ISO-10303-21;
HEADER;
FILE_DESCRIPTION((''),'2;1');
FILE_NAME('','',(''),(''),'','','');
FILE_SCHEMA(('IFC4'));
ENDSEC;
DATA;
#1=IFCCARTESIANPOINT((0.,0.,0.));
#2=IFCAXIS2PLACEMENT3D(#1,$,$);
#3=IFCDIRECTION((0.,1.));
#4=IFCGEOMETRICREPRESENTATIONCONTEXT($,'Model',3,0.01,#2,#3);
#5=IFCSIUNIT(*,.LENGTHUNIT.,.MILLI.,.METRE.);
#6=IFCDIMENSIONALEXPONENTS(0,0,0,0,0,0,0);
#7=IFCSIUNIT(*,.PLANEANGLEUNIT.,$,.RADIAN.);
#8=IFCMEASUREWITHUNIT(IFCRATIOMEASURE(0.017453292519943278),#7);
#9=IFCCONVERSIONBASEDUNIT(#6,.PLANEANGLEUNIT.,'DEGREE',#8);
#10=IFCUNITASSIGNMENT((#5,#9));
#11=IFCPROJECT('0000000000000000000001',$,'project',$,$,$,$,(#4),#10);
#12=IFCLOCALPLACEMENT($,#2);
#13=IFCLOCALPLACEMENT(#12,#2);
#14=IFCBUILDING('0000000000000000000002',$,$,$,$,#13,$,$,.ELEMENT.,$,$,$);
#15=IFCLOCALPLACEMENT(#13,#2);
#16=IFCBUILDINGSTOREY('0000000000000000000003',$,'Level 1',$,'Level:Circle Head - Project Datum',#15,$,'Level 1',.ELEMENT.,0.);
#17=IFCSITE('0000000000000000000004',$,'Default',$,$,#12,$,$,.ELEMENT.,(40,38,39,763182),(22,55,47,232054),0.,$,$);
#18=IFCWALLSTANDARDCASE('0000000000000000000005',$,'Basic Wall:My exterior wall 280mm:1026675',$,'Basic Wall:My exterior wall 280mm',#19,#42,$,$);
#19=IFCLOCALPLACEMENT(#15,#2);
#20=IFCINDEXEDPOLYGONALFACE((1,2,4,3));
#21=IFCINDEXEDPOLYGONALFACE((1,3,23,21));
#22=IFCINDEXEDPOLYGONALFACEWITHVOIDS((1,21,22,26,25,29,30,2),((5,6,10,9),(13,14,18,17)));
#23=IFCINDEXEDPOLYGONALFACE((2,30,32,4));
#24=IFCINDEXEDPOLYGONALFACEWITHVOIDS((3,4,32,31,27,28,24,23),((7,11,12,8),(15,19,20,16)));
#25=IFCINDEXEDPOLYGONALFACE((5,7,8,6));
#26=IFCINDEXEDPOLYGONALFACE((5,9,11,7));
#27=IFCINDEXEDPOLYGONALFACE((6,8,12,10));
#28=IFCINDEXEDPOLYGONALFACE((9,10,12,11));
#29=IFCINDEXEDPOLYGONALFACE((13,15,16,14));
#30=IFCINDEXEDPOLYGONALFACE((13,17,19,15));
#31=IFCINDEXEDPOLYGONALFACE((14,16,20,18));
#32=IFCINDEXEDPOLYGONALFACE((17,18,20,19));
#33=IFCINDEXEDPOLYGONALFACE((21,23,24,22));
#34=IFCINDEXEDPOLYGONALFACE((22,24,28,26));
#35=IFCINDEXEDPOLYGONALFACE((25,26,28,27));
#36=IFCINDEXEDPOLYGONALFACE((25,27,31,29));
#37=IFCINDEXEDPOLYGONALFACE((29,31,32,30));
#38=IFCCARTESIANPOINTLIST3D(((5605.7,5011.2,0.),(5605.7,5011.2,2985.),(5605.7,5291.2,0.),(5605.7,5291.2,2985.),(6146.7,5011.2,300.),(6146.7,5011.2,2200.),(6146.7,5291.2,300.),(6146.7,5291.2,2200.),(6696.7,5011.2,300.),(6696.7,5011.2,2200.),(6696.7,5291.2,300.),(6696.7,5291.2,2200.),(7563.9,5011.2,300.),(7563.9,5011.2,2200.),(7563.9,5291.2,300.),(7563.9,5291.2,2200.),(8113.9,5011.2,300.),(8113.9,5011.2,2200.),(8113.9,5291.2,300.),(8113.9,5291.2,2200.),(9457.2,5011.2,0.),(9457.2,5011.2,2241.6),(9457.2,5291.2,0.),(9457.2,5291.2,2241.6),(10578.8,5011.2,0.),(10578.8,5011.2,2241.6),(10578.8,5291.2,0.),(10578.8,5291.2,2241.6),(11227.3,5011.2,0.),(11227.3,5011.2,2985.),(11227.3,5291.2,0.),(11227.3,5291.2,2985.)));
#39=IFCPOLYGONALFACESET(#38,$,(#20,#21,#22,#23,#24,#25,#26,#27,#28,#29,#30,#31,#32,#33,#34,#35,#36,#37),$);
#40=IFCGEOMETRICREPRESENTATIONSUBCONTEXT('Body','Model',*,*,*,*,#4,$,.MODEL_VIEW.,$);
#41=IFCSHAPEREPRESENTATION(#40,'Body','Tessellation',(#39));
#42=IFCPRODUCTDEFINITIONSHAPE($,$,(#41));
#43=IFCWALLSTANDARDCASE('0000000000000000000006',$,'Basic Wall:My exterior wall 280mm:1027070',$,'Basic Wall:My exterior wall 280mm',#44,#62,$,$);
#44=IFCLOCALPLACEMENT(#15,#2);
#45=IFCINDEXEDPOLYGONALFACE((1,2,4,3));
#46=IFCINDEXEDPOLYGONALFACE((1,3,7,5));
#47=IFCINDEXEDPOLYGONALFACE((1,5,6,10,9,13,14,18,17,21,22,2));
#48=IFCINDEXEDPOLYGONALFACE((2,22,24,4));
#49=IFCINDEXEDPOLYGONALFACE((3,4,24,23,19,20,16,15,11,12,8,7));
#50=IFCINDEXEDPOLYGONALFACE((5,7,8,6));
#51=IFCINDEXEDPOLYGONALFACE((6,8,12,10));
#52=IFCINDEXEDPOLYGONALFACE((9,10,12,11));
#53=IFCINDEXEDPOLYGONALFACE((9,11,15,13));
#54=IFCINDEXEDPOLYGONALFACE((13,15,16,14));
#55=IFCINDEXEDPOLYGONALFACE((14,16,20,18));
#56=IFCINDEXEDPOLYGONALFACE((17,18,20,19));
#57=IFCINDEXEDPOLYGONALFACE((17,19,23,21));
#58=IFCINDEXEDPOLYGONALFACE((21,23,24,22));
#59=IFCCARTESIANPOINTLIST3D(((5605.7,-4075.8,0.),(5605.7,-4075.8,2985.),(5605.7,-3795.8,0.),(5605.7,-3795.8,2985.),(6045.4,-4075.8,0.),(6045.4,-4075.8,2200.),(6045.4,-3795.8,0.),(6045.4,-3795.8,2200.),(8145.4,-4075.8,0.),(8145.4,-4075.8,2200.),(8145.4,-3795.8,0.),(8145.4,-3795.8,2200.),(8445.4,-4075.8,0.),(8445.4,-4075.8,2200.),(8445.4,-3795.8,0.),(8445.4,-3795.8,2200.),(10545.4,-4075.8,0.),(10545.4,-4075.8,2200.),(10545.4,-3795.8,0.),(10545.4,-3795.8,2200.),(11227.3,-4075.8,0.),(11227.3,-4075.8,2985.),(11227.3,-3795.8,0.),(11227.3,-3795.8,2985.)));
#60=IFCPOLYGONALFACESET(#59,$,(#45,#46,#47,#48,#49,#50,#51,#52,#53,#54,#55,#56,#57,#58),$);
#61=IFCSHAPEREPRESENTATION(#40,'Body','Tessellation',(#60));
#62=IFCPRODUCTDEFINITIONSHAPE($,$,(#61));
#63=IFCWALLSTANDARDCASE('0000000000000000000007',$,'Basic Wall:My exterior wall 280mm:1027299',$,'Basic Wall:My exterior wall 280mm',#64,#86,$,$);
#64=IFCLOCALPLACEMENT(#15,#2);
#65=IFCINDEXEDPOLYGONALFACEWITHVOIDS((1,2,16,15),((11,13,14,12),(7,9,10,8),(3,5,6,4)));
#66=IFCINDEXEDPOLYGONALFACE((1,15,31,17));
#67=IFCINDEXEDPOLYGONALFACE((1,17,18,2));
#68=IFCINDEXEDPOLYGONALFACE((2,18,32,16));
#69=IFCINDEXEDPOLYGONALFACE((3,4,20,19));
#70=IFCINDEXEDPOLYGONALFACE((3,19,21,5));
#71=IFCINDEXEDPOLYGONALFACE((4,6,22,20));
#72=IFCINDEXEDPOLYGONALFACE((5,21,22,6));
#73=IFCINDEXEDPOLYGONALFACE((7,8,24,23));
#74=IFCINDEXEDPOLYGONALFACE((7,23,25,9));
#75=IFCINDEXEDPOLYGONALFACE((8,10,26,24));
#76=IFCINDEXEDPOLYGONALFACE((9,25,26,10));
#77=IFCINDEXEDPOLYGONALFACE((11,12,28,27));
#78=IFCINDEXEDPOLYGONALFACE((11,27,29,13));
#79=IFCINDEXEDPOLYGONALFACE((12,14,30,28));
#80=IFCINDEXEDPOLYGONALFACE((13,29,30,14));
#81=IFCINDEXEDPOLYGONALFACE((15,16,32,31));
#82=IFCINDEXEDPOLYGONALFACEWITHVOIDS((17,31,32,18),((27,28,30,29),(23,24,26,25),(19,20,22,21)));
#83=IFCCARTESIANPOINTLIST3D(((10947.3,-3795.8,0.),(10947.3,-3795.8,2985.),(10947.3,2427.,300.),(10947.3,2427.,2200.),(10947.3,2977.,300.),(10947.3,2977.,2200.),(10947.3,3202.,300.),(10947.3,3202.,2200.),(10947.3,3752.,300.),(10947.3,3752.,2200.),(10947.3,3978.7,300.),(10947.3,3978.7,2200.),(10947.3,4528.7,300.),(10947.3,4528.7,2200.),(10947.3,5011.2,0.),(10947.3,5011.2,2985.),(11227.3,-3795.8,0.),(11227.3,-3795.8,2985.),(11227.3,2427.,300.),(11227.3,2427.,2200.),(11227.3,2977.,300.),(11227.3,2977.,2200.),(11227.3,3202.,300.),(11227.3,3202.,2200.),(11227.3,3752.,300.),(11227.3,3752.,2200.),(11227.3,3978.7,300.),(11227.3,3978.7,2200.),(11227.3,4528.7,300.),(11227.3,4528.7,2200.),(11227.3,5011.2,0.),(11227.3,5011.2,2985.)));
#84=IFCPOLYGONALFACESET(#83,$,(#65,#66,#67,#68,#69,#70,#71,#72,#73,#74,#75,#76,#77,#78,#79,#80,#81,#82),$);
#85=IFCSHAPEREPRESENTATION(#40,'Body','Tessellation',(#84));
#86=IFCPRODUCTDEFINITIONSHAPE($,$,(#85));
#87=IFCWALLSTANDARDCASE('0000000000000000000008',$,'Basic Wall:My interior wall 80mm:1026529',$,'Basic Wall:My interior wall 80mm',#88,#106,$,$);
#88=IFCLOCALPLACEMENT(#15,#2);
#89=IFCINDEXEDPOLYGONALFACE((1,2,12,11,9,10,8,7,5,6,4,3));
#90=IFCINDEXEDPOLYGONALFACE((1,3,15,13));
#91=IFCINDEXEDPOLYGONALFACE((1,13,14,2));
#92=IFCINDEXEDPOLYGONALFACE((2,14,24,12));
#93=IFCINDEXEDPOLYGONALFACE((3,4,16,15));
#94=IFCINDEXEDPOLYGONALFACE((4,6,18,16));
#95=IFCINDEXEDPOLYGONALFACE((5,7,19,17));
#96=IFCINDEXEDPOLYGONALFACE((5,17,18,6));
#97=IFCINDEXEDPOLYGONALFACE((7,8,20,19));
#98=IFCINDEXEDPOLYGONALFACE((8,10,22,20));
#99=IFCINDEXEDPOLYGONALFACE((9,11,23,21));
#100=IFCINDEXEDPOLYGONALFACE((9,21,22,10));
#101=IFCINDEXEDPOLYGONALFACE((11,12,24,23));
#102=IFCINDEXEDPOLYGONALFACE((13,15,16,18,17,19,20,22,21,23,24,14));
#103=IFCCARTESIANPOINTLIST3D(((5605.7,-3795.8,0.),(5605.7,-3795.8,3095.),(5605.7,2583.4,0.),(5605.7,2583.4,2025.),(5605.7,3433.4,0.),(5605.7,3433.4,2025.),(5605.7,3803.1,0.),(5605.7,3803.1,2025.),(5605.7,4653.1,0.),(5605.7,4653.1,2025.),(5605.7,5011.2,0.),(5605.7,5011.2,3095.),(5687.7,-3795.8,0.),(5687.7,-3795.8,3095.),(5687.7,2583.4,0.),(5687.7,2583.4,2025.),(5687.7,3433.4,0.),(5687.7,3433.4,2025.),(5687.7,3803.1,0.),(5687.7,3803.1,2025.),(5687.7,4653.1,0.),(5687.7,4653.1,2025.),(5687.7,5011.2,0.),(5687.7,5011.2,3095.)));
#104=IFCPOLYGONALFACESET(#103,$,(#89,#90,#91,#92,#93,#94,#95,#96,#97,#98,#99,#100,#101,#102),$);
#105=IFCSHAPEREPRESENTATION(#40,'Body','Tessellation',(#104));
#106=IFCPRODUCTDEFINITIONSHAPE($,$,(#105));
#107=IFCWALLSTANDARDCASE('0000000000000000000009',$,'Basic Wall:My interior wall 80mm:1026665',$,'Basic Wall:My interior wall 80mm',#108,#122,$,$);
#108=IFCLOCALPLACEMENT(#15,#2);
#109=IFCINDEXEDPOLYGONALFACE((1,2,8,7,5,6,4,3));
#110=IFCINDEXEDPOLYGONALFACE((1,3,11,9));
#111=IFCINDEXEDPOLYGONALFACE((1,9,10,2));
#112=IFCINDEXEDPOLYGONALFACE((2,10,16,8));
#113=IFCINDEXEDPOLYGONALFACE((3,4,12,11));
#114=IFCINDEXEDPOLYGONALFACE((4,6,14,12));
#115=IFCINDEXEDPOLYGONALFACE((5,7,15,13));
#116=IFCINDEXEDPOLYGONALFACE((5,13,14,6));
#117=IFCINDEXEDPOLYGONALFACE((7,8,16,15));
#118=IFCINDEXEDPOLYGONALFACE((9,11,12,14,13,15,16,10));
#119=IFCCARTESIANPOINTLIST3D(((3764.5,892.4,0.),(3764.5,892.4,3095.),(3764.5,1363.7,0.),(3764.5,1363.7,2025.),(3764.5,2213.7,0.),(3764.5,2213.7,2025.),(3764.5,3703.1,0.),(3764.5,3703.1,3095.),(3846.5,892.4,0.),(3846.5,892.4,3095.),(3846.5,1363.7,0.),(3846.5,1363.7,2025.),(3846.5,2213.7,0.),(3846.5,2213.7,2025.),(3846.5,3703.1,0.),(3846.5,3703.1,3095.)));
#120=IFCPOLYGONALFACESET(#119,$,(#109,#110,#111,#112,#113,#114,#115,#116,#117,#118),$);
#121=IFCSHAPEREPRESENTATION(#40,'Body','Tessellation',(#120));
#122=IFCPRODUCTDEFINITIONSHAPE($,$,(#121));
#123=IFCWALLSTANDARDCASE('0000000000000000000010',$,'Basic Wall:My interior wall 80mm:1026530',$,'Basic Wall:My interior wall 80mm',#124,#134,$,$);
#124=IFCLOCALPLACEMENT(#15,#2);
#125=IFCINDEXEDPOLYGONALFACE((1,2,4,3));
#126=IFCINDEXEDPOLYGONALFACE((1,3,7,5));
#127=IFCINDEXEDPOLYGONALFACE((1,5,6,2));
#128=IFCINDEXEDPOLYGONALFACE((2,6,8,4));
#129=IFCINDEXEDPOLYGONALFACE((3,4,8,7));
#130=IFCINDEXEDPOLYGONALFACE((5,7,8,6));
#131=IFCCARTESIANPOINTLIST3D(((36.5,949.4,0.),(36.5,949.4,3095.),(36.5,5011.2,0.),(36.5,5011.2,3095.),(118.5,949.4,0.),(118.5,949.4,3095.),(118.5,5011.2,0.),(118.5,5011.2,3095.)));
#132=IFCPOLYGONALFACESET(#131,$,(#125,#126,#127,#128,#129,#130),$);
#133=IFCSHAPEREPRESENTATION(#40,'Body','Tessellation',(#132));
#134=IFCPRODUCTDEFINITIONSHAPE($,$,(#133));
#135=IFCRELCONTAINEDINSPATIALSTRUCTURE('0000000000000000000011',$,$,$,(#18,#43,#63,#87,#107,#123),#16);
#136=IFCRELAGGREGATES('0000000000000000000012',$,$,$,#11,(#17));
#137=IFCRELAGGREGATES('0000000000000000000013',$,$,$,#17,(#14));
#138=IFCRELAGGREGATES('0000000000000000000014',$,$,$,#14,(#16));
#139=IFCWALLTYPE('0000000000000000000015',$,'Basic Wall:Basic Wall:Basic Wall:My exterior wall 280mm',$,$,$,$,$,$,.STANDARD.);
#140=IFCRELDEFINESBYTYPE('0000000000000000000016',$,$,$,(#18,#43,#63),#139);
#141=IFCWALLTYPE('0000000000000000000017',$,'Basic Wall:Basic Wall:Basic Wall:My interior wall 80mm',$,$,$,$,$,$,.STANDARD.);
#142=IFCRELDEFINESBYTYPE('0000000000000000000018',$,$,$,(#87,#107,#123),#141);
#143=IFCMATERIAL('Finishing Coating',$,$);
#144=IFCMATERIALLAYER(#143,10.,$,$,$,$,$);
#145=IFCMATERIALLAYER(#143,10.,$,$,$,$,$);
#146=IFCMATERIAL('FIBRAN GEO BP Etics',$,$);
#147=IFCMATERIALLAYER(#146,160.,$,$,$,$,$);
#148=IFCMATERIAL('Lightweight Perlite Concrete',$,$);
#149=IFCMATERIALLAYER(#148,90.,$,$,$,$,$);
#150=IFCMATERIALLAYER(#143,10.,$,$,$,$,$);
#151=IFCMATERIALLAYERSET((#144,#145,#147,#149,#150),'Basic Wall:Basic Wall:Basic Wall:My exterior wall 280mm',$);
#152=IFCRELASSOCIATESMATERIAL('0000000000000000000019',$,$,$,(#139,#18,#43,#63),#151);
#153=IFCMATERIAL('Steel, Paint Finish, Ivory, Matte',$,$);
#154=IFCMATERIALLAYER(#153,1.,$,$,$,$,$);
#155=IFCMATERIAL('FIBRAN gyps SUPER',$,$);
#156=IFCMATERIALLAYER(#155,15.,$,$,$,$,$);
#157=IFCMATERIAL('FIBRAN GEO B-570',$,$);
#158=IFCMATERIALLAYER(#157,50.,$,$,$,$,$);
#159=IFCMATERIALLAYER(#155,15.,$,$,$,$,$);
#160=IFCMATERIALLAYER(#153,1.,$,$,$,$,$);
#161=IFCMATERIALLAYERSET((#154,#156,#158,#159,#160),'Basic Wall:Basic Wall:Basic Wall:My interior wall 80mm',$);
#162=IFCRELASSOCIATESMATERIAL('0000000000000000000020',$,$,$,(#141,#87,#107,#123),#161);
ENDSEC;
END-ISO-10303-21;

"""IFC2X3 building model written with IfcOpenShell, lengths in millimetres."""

from ifc_helpers import new_model, entity, si_unit, converted_unit, direction, frame, frame_2d, origin, origin_2d_with_axis, place, context, subcontext, project, spatial, rectangle, extrude, material, layer, layer_set, layer_usage, type_object, element, save


model = new_model("IFC2X3")

# Units and contexts
model_context = context("Model", 3, precision=0.01, world=origin(), true_north=direction((0.0, 1.0)))
body_context = subcontext(model_context, "Body", "Model", "MODEL_VIEW")
ifc_project = project(units=[si_unit("LENGTHUNIT", "METRE", prefix="MILLI"), converted_unit("PLANEANGLEUNIT", "DEGREE", entity("IfcRatioMeasure", 0.017453292519943278), si_unit("PLANEANGLEUNIT", "RADIAN"), dimensions=[0, 0, 0, 0, 0, 0, 0])], contexts=[model_context])

# Site, building, storey
site_placement = place(None, origin())
site = spatial("IfcSite", under=ifc_project, at=site_placement, Name="Default", CompositionType="ELEMENT", RefLatitude=(40, 38, 39, 763182), RefLongitude=(22, 55, 47, 232054), RefElevation=0.0)
building_placement = place(site_placement, origin())
building = spatial("IfcBuilding", under=site, at=building_placement, CompositionType="ELEMENT")
storey_placement = place(building_placement, origin())
storey = spatial("IfcBuildingStorey", under=building, at=storey_placement, Name="Level 1", ObjectType="Level:Circle Head - Project Datum", LongName="Level 1", CompositionType="ELEMENT", Elevation=0.0)

# Shared definitions
ifc_material_1 = material(Name="FIBRAN gyps SUPER")

# Walls, openings
ifc_material_2 = material(Name="Finishing Coating")
ifc_layer_1 = layer(ifc_material_2, 10.0)
ifc_layer_2 = layer(ifc_material_2, 10.0)
ifc_material_3 = material(Name="FIBRAN GEO BP Etics")
ifc_layer_3 = layer(ifc_material_3, 160.0)
ifc_material_4 = material(Name="Lightweight Perlite Concrete")
ifc_layer_4 = layer(ifc_material_4, 90.0)
ifc_layer_5 = layer(ifc_material_2, 10.0)
ifc_layer_set_1 = layer_set([ifc_layer_1, ifc_layer_2, ifc_layer_3, ifc_layer_4, ifc_layer_5], Name="Basic Wall:Basic Wall:Basic Wall:My exterior wall 280mm")
ifc_layer_usage_1 = layer_usage(ifc_layer_set_1, "AXIS2", "NEGATIVE", 140.0)
wall_type_1 = type_object("IfcWallType", Name="Basic Wall:Basic Wall:Basic Wall:My exterior wall 280mm", PredefinedType="STANDARD", material=ifc_layer_set_1)
wall_1_placement = place(storey_placement, frame((5605.7, 5151.2, 0.0)))
wall_1 = element("IfcWallStandardCase", 1, at=wall_1_placement, inside=storey, type_object=wall_type_1, material=ifc_layer_usage_1, Name="Basic Wall:My exterior wall 280mm:1026675", ObjectType="Basic Wall:My exterior wall 280mm", context=body_context, shape_type="SweptSolid", body=[
    extrude(rectangle(XDim=5621.6, YDim=280.0, at=frame_2d((2810.8, 0.0), x_axis=(1.0, 0.0))), origin(), (0.0, 0.0, 1.0), 2985.0),
])
opening_1_placement = place(wall_1_placement, origin())
element("IfcOpeningElement", 2, at=opening_1_placement, cuts=wall_1, ObjectType="Opening", context=body_context, shape_type="SweptSolid", body=[
    extrude(rectangle(XDim=2241.6, YDim=1121.6, at=frame_2d((0.0, 0.0), x_axis=(1.0, 0.0))), frame((4412.3, -140.0, 1120.8), z_axis=(0.0, 1.0, 0.0), x_axis=(0.0, 0.0, -1.0)), (0.0, 0.0, 1.0), 280.0),
])
opening_2_placement = place(wall_1_placement, origin())
element("IfcOpeningElement", 3, at=opening_2_placement, cuts=wall_1, ObjectType="Opening", context=body_context, shape_type="SweptSolid", body=[
    extrude(rectangle(XDim=1900.0, YDim=550.0, at=frame_2d((0.0, 0.0), x_axis=(1.0, 0.0))), frame((816.0, -140.0, 1250.0), z_axis=(0.0, 1.0, 0.0), x_axis=(0.0, 0.0, -1.0)), (0.0, 0.0, 1.0), 280.0),
])
opening_3_placement = place(wall_1_placement, origin())
element("IfcOpeningElement", 4, at=opening_3_placement, cuts=wall_1, ObjectType="Opening", context=body_context, shape_type="SweptSolid", body=[
    extrude(rectangle(XDim=1900.0, YDim=550.0, at=frame_2d((0.0, 0.0), x_axis=(1.0, 0.0))), frame((2233.1, -140.0, 1250.0), z_axis=(0.0, 1.0, 0.0), x_axis=(0.0, 0.0, -1.0)), (0.0, 0.0, 1.0), 280.0),
])
ifc_layer_usage_2 = layer_usage(ifc_layer_set_1, "AXIS2", "NEGATIVE", 140.0)
wall_2_placement = place(storey_placement, frame((11227.3, -3935.8, 0.0), z_axis=(0.0, 0.0, 1.0), x_axis=(-1.0, 0.0, 0.0)))
wall_2 = element("IfcWallStandardCase", 5, at=wall_2_placement, inside=storey, type_object=wall_type_1, material=ifc_layer_usage_2, Name="Basic Wall:My exterior wall 280mm:1027070", ObjectType="Basic Wall:My exterior wall 280mm", context=body_context, shape_type="SweptSolid", body=[
    extrude(rectangle(XDim=5621.6, YDim=280.0, at=frame_2d((2810.8, 0.0), x_axis=(1.0, 0.0))), origin(), (0.0, 0.0, 1.0), 2985.0),
])
opening_4_placement = place(wall_2_placement, origin())
element("IfcOpeningElement", 6, at=opening_4_placement, cuts=wall_2, ObjectType="Opening", context=body_context, shape_type="SweptSolid", body=[
    extrude(rectangle(XDim=2200.0, YDim=2100.0, at=frame_2d((0.0, 0.0), x_axis=(1.0, 0.0))), frame((4131.9, -140.0, 1100.0), z_axis=(0.0, 1.0, 0.0), x_axis=(0.0, 0.0, -1.0)), (0.0, 0.0, 1.0), 280.0),
])
opening_5_placement = place(wall_2_placement, origin())
element("IfcOpeningElement", 7, at=opening_5_placement, cuts=wall_2, ObjectType="Opening", context=body_context, shape_type="SweptSolid", body=[
    extrude(rectangle(XDim=2200.0, YDim=2100.0, at=frame_2d((0.0, 0.0), x_axis=(1.0, 0.0))), frame((1731.9, -140.0, 1100.0), z_axis=(0.0, 1.0, 0.0), x_axis=(0.0, 0.0, -1.0)), (0.0, 0.0, 1.0), 280.0),
])
ifc_layer_usage_3 = layer_usage(ifc_layer_set_1, "AXIS2", "NEGATIVE", 140.0)
wall_3_placement = place(storey_placement, frame((11087.3, -3795.8, 0.0), z_axis=(0.0, 0.0, 1.0), x_axis=(0.0, 1.0, 0.0)))
wall_3 = element("IfcWallStandardCase", 8, at=wall_3_placement, inside=storey, type_object=wall_type_1, material=ifc_layer_usage_3, Name="Basic Wall:My exterior wall 280mm:1027299", ObjectType="Basic Wall:My exterior wall 280mm", context=body_context, shape_type="SweptSolid", body=[
    extrude(rectangle(XDim=8807.0, YDim=280.0, at=frame_2d((4403.5, 0.0), x_axis=(-1.0, 0.0))), origin(), (0.0, 0.0, 1.0), 2985.0),
])
opening_6_placement = place(wall_3_placement, origin())
element("IfcOpeningElement", 9, at=opening_6_placement, cuts=wall_3, ObjectType="Opening", context=body_context, shape_type="SweptSolid", body=[
    extrude(rectangle(XDim=1900.0, YDim=550.0, at=frame_2d((0.0, 0.0), x_axis=(1.0, 0.0))), frame((6497.9, -140.0, 1250.0), z_axis=(0.0, 1.0, 0.0), x_axis=(0.0, 0.0, -1.0)), (0.0, 0.0, 1.0), 280.0),
])
opening_7_placement = place(wall_3_placement, origin())
element("IfcOpeningElement", 10, at=opening_7_placement, cuts=wall_3, ObjectType="Opening", context=body_context, shape_type="SweptSolid", body=[
    extrude(rectangle(XDim=1900.0, YDim=550.0, at=frame_2d((0.0, 0.0), x_axis=(1.0, 0.0))), frame((7272.9, -140.0, 1250.0), z_axis=(0.0, 1.0, 0.0), x_axis=(0.0, 0.0, -1.0)), (0.0, 0.0, 1.0), 280.0),
])
opening_8_placement = place(wall_3_placement, origin())
element("IfcOpeningElement", 11, at=opening_8_placement, cuts=wall_3, ObjectType="Opening", context=body_context, shape_type="SweptSolid", body=[
    extrude(rectangle(XDim=1900.0, YDim=550.0, at=frame_2d((0.0, 0.0), x_axis=(1.0, 0.0))), frame((8049.6, -140.0, 1250.0), z_axis=(0.0, 1.0, 0.0), x_axis=(0.0, 0.0, -1.0)), (0.0, 0.0, 1.0), 280.0),
])
ifc_material_5 = material(Name="Steel, Paint Finish, Ivory, Matte")
ifc_layer_6 = layer(ifc_material_5, 1.0)
ifc_layer_7 = layer(ifc_material_1, 15.0)
ifc_material_6 = material(Name="FIBRAN GEO B-570")
ifc_layer_8 = layer(ifc_material_6, 50.0)
ifc_layer_9 = layer(ifc_material_1, 15.0)
ifc_layer_10 = layer(ifc_material_5, 1.0)
ifc_layer_set_2 = layer_set([ifc_layer_6, ifc_layer_7, ifc_layer_8, ifc_layer_9, ifc_layer_10], Name="Basic Wall:Basic Wall:Basic Wall:My interior wall 80mm")
ifc_layer_usage_4 = layer_usage(ifc_layer_set_2, "AXIS2", "NEGATIVE", 41.0)
wall_type_2 = type_object("IfcWallType", Name="Basic Wall:Basic Wall:Basic Wall:My interior wall 80mm", PredefinedType="STANDARD", material=ifc_layer_set_2)
wall_4_placement = place(storey_placement, frame((5646.7, -3795.8, 0.0), z_axis=(0.0, 0.0, 1.0), x_axis=(0.0, 1.0, 0.0)))
wall_4 = element("IfcWallStandardCase", 12, at=wall_4_placement, inside=storey, type_object=wall_type_2, material=ifc_layer_usage_4, Name="Basic Wall:My interior wall 80mm:1026529", ObjectType="Basic Wall:My interior wall 80mm", context=body_context, shape_type="SweptSolid", body=[
    extrude(rectangle(XDim=8807.0, YDim=82.0, at=frame_2d((4403.5, 0.0), x_axis=(1.0, 0.0))), origin(), (0.0, 0.0, 1.0), 3095.0),
])
opening_9_placement = place(wall_4_placement, origin())
element("IfcOpeningElement", 13, at=opening_9_placement, cuts=wall_4, ObjectType="Opening", context=body_context, shape_type="SweptSolid", body=[
    extrude(rectangle(XDim=2025.0, YDim=850.0, at=origin_2d_with_axis()), frame((8024.0, -41.0, 1012.5), z_axis=(0.0, 1.0, 0.0), x_axis=(0.0, 0.0, -1.0)), (0.0, 0.0, 1.0), 82.0),
])
opening_10_placement = place(wall_4_placement, origin())
element("IfcOpeningElement", 14, at=opening_10_placement, cuts=wall_4, ObjectType="Opening", context=body_context, shape_type="SweptSolid", body=[
    extrude(rectangle(XDim=2025.0, YDim=850.0, at=origin_2d_with_axis()), frame((6804.2, -41.0, 1012.5), z_axis=(0.0, 1.0, 0.0), x_axis=(0.0, 0.0, -1.0)), (0.0, 0.0, 1.0), 82.0),
])

# Wall, opening
ifc_layer_usage_5 = layer_usage(ifc_layer_set_2, "AXIS2", "NEGATIVE", 41.0)
wall_5_placement = place(storey_placement, frame((3805.5, 3703.1, 0.0), z_axis=(0.0, 0.0, 1.0), x_axis=(0.0, -1.0, 0.0)))
wall_5 = element("IfcWallStandardCase", 15, at=wall_5_placement, inside=storey, type_object=wall_type_2, material=ifc_layer_usage_5, Name="Basic Wall:My interior wall 80mm:1026665", ObjectType="Basic Wall:My interior wall 80mm", context=body_context, shape_type="SweptSolid", body=[
    extrude(rectangle(XDim=2810.7, YDim=82.0, at=frame_2d((1405.4, 0.0), x_axis=(1.0, 0.0))), origin(), (0.0, 0.0, 1.0), 3095.0),
])
opening_11_placement = place(wall_5_placement, origin())
element("IfcOpeningElement", 16, at=opening_11_placement, cuts=wall_5, ObjectType="Opening", context=body_context, shape_type="SweptSolid", body=[
    extrude(rectangle(XDim=2025.0, YDim=850.0, at=frame_2d((0.0, 0.0), x_axis=(1.0, 0.0))), frame((1914.5, -41.0, 1012.5), z_axis=(0.0, 1.0, 0.0), x_axis=(0.0, 0.0, -1.0)), (0.0, 0.0, 1.0), 82.0),
])

# Wall
ifc_layer_usage_6 = layer_usage(ifc_layer_set_2, "AXIS2", "NEGATIVE", 41.0)
wall_6_placement = place(storey_placement, frame((77.5, 949.4, 0.0), z_axis=(0.0, 0.0, 1.0), x_axis=(0.0, 1.0, 0.0)))
element("IfcWallStandardCase", 17, at=wall_6_placement, inside=storey, type_object=wall_type_2, material=ifc_layer_usage_6, Name="Basic Wall:My interior wall 80mm:1026530", ObjectType="Basic Wall:My interior wall 80mm", context=body_context, shape_type="SweptSolid", body=[
    extrude(rectangle(XDim=4061.8, YDim=82.0, at=frame_2d((2030.9, 0.0), x_axis=(-1.0, 0.0))), origin(), (0.0, 0.0, 1.0), 3095.0),
])

save(model, "model.ifc")
